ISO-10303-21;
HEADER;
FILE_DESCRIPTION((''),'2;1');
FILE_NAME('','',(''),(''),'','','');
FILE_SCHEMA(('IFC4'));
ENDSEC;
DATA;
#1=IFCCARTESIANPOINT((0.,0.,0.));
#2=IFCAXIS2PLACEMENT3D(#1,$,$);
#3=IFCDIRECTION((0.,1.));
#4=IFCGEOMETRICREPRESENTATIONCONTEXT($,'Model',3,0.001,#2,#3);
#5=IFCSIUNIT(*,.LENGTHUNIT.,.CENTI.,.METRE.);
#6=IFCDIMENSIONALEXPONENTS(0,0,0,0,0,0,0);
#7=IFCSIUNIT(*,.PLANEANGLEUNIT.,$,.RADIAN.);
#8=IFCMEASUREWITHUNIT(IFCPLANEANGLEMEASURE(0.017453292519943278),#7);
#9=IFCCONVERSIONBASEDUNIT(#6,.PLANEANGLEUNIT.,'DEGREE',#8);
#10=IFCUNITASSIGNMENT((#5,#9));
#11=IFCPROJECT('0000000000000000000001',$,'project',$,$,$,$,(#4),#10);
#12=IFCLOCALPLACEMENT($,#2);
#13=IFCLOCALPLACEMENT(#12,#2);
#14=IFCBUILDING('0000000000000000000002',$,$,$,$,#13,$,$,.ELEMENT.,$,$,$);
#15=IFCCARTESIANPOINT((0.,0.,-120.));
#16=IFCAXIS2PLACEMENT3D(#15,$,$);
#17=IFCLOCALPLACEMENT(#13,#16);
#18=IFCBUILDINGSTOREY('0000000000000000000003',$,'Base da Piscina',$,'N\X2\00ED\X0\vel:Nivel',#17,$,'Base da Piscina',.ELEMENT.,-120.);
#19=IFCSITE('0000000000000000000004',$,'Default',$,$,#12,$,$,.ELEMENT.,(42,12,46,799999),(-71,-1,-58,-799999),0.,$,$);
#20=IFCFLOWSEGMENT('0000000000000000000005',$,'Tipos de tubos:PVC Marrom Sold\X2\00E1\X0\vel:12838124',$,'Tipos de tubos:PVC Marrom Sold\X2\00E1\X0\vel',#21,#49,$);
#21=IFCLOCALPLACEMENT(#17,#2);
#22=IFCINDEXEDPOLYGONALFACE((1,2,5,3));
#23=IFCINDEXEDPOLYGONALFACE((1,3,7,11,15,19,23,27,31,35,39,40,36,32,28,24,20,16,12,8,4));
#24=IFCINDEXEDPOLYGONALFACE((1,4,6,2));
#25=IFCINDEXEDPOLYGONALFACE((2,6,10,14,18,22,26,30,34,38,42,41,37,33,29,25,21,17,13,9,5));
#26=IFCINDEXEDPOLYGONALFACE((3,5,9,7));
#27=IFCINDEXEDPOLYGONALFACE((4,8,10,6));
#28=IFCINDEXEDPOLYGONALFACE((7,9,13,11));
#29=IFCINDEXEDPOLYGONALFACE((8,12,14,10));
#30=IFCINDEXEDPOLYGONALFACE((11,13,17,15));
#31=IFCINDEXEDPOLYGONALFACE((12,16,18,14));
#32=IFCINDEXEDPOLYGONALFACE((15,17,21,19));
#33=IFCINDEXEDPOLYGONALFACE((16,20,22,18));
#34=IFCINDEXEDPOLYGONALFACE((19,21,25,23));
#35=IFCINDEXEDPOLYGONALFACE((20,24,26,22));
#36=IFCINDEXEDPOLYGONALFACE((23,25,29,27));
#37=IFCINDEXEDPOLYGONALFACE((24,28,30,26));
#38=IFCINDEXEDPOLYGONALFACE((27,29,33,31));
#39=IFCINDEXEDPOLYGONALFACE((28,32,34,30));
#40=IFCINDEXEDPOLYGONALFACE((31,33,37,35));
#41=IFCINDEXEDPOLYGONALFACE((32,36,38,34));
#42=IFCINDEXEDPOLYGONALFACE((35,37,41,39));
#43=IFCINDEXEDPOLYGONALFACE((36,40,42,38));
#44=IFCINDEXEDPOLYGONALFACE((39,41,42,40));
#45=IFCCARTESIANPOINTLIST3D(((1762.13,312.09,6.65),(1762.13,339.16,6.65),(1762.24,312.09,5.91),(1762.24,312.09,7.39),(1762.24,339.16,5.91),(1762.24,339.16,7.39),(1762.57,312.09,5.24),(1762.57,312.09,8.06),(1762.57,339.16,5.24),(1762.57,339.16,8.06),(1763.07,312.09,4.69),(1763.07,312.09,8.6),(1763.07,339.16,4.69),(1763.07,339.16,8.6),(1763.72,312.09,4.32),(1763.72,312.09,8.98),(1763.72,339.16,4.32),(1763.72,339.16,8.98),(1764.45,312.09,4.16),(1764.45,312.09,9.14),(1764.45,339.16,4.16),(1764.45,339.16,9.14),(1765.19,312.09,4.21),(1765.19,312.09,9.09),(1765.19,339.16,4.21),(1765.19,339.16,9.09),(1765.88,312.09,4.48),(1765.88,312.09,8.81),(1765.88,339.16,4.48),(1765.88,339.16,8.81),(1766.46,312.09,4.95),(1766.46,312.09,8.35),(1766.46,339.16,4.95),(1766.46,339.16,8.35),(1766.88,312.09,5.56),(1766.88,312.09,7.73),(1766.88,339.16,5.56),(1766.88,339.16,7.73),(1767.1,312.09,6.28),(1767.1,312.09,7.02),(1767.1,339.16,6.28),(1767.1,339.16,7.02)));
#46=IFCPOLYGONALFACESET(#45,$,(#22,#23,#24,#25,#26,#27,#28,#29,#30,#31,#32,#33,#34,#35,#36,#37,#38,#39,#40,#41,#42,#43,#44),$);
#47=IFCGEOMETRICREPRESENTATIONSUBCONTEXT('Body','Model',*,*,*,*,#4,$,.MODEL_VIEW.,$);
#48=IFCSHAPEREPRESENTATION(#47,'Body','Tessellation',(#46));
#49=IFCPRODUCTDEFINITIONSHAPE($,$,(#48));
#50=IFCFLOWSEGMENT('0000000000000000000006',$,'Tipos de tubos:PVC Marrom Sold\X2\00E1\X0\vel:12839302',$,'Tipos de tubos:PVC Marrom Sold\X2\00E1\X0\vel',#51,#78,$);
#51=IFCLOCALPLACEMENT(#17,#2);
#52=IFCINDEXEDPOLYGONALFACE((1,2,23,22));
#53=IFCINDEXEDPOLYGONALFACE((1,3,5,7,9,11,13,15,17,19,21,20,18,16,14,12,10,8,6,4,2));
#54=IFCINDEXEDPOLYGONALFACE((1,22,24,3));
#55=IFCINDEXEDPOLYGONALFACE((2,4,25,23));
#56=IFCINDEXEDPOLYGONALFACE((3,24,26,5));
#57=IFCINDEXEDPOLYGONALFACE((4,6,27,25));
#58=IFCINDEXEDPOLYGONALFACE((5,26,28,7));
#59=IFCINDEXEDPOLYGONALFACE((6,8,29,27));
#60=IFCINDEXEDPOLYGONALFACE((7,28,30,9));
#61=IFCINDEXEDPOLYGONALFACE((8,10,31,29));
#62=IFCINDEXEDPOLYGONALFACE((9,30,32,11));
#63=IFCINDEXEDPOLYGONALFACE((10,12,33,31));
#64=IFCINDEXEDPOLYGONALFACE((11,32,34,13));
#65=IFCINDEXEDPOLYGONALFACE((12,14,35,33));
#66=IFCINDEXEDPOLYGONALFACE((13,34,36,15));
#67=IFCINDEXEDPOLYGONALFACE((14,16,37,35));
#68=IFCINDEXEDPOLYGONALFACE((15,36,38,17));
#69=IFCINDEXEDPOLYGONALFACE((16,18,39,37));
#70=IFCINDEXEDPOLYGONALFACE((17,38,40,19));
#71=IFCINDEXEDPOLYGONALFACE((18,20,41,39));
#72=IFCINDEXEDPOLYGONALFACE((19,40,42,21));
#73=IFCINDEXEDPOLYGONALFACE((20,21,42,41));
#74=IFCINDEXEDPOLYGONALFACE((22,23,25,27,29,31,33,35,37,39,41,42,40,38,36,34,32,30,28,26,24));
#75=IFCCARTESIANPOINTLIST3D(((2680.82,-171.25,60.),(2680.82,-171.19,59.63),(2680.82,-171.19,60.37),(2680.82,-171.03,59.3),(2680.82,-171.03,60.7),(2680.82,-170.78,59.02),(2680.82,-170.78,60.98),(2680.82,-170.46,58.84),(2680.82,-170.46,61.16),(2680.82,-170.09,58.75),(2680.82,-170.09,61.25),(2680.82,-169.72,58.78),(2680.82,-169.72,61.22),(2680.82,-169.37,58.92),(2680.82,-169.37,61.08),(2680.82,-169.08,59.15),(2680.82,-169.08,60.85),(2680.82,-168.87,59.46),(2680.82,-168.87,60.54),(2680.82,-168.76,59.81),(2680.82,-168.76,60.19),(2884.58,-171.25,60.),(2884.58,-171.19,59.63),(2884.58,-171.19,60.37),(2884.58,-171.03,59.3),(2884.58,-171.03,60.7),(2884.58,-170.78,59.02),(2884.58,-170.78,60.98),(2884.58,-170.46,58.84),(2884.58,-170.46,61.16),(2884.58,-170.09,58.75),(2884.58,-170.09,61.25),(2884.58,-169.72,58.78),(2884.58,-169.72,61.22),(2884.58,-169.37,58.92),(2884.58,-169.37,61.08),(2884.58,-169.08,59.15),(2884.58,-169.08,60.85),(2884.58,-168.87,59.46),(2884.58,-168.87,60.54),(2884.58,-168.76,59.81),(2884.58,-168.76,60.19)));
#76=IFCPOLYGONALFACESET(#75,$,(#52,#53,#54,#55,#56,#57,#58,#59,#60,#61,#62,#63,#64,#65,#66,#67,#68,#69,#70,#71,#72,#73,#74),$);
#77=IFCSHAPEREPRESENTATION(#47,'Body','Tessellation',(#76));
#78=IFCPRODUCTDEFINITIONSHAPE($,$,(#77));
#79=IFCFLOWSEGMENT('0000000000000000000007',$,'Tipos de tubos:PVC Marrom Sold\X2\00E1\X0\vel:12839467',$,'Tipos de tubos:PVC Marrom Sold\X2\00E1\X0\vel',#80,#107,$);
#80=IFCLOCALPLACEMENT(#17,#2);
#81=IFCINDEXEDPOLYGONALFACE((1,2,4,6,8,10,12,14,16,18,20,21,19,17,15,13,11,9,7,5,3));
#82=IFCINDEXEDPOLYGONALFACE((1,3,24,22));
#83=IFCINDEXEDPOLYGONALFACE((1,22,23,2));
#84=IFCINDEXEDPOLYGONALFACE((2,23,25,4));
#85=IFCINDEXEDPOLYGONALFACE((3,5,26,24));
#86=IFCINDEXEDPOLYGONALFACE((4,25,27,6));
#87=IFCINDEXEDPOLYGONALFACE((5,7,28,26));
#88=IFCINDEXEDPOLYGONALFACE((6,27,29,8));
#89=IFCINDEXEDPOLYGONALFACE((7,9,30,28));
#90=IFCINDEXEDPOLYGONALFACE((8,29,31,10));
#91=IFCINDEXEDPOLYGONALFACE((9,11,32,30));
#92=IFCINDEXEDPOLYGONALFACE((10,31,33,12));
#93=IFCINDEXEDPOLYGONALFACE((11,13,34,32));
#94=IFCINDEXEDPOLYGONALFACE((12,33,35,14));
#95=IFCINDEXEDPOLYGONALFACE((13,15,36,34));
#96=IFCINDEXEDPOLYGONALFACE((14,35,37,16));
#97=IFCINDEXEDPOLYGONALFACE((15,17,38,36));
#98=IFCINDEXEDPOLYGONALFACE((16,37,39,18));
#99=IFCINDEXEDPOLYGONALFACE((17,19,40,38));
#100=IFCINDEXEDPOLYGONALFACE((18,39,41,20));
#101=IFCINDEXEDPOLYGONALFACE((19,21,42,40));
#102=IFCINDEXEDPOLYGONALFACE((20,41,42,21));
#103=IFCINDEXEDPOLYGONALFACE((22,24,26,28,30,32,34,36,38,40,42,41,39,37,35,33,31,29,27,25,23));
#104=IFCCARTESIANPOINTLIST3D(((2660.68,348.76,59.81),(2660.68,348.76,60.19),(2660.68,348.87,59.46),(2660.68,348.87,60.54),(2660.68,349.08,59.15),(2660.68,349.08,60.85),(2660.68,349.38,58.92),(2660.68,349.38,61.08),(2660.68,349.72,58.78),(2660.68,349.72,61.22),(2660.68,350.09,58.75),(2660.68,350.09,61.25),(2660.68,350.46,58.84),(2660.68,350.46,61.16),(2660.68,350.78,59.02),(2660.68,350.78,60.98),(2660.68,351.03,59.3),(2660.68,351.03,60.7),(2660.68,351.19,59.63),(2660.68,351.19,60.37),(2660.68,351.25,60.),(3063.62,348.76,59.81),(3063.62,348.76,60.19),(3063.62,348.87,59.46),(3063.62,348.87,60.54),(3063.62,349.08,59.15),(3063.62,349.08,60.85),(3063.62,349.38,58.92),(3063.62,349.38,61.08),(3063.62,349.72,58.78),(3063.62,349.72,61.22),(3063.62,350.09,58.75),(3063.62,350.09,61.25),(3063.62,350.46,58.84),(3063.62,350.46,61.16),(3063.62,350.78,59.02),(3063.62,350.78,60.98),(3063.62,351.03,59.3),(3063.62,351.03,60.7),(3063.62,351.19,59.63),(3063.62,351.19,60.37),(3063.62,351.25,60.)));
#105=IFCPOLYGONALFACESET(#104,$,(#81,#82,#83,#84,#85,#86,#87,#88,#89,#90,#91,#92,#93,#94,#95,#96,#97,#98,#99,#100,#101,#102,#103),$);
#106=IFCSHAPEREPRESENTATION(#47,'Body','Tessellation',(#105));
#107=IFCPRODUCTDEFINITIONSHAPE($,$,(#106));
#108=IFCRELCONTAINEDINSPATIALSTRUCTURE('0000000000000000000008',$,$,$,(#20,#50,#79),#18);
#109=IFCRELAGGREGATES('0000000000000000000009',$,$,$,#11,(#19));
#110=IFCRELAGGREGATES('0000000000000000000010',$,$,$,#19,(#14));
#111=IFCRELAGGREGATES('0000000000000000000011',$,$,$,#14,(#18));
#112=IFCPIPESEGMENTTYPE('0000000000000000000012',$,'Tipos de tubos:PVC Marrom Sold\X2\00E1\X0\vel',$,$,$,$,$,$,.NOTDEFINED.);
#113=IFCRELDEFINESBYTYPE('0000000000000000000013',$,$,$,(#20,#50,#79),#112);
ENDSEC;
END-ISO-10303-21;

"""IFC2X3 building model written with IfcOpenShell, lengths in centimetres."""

from ifc_helpers import new_model, entity, si_unit, converted_unit, direction, frame, frame_2d, origin, origin_2d_with_axis, place, context, subcontext, project, spatial, circle, extrude, type_object, element, save


model = new_model("IFC2X3")

# Units and contexts
model_context = context("Model", 3, precision=0.001, world=origin(), true_north=direction((0.0, 1.0)))
body_context = subcontext(model_context, "Body", "Model", "MODEL_VIEW")
ifc_project = project(units=[si_unit("LENGTHUNIT", "METRE", prefix="CENTI"), converted_unit("PLANEANGLEUNIT", "DEGREE", entity("IfcPlaneAngleMeasure", 0.017453292519943278), si_unit("PLANEANGLEUNIT", "RADIAN"), dimensions=[0, 0, 0, 0, 0, 0, 0])], contexts=[model_context])

# Site, building, storey
site_placement = place(None, origin())
site = spatial("IfcSite", under=ifc_project, at=site_placement, Name="Default", CompositionType="ELEMENT", RefLatitude=(42, 12, 46, 799999), RefLongitude=(-71, -1, -58, -799999), RefElevation=0.0)
building_placement = place(site_placement, origin())
building = spatial("IfcBuilding", under=site, at=building_placement, CompositionType="ELEMENT")
storey_placement = place(building_placement, frame((0.0, 0.0, -120.0)))
storey = spatial("IfcBuildingStorey", under=building, at=storey_placement, Name="Base da Piscina", ObjectType="Nível:Nivel", LongName="Base da Piscina", CompositionType="ELEMENT", Elevation=-120.0)

# Flow segments
pipe_segment_type = type_object("IfcPipeSegmentType", Name="Tipos de tubos:PVC Marrom Soldável", PredefinedType="NOTDEFINED")
flow_segment_1_placement = place(storey_placement, origin())
element("IfcFlowSegment", 1, at=flow_segment_1_placement, inside=storey, type_object=pipe_segment_type, Name="Tipos de tubos:PVC Marrom Soldável:12838124", ObjectType="Tipos de tubos:PVC Marrom Soldável", context=body_context, shape_type="SweptSolid", body=[
    extrude(circle(Radius=2.5, at=origin_2d_with_axis()), frame((1764.63, 312.09, 6.65), z_axis=(0.0, 1.0, 0.0), x_axis=(-1.0, 0.0, 0.0)), (0.0, 0.0, 1.0), 27.07),
])
flow_segment_2_placement = place(storey_placement, origin())
element("IfcFlowSegment", 2, at=flow_segment_2_placement, inside=storey, type_object=pipe_segment_type, Name="Tipos de tubos:PVC Marrom Soldável:12839302", ObjectType="Tipos de tubos:PVC Marrom Soldável", context=body_context, shape_type="SweptSolid", body=[
    extrude(circle(Radius=1.25, at=origin_2d_with_axis()), frame((2680.82, -170.0, 60.0), z_axis=(1.0, 0.0, 0.0), x_axis=(0.0, -1.0, 0.0)), (0.0, 0.0, 1.0), 203.76),
])
flow_segment_3_placement = place(storey_placement, origin())
element("IfcFlowSegment", 3, at=flow_segment_3_placement, inside=storey, type_object=pipe_segment_type, Name="Tipos de tubos:PVC Marrom Soldável:12839467", ObjectType="Tipos de tubos:PVC Marrom Soldável", context=body_context, shape_type="SweptSolid", body=[
    extrude(circle(Radius=1.25, at=frame_2d((0.0, 0.0), x_axis=(1.0, 0.0))), frame((2660.68, 350.0, 60.0), z_axis=(1.0, 0.0, 0.0), x_axis=(0.0, 1.0, 0.0)), (0.0, 0.0, 1.0), 402.94),
])

save(model, "model.ifc")
